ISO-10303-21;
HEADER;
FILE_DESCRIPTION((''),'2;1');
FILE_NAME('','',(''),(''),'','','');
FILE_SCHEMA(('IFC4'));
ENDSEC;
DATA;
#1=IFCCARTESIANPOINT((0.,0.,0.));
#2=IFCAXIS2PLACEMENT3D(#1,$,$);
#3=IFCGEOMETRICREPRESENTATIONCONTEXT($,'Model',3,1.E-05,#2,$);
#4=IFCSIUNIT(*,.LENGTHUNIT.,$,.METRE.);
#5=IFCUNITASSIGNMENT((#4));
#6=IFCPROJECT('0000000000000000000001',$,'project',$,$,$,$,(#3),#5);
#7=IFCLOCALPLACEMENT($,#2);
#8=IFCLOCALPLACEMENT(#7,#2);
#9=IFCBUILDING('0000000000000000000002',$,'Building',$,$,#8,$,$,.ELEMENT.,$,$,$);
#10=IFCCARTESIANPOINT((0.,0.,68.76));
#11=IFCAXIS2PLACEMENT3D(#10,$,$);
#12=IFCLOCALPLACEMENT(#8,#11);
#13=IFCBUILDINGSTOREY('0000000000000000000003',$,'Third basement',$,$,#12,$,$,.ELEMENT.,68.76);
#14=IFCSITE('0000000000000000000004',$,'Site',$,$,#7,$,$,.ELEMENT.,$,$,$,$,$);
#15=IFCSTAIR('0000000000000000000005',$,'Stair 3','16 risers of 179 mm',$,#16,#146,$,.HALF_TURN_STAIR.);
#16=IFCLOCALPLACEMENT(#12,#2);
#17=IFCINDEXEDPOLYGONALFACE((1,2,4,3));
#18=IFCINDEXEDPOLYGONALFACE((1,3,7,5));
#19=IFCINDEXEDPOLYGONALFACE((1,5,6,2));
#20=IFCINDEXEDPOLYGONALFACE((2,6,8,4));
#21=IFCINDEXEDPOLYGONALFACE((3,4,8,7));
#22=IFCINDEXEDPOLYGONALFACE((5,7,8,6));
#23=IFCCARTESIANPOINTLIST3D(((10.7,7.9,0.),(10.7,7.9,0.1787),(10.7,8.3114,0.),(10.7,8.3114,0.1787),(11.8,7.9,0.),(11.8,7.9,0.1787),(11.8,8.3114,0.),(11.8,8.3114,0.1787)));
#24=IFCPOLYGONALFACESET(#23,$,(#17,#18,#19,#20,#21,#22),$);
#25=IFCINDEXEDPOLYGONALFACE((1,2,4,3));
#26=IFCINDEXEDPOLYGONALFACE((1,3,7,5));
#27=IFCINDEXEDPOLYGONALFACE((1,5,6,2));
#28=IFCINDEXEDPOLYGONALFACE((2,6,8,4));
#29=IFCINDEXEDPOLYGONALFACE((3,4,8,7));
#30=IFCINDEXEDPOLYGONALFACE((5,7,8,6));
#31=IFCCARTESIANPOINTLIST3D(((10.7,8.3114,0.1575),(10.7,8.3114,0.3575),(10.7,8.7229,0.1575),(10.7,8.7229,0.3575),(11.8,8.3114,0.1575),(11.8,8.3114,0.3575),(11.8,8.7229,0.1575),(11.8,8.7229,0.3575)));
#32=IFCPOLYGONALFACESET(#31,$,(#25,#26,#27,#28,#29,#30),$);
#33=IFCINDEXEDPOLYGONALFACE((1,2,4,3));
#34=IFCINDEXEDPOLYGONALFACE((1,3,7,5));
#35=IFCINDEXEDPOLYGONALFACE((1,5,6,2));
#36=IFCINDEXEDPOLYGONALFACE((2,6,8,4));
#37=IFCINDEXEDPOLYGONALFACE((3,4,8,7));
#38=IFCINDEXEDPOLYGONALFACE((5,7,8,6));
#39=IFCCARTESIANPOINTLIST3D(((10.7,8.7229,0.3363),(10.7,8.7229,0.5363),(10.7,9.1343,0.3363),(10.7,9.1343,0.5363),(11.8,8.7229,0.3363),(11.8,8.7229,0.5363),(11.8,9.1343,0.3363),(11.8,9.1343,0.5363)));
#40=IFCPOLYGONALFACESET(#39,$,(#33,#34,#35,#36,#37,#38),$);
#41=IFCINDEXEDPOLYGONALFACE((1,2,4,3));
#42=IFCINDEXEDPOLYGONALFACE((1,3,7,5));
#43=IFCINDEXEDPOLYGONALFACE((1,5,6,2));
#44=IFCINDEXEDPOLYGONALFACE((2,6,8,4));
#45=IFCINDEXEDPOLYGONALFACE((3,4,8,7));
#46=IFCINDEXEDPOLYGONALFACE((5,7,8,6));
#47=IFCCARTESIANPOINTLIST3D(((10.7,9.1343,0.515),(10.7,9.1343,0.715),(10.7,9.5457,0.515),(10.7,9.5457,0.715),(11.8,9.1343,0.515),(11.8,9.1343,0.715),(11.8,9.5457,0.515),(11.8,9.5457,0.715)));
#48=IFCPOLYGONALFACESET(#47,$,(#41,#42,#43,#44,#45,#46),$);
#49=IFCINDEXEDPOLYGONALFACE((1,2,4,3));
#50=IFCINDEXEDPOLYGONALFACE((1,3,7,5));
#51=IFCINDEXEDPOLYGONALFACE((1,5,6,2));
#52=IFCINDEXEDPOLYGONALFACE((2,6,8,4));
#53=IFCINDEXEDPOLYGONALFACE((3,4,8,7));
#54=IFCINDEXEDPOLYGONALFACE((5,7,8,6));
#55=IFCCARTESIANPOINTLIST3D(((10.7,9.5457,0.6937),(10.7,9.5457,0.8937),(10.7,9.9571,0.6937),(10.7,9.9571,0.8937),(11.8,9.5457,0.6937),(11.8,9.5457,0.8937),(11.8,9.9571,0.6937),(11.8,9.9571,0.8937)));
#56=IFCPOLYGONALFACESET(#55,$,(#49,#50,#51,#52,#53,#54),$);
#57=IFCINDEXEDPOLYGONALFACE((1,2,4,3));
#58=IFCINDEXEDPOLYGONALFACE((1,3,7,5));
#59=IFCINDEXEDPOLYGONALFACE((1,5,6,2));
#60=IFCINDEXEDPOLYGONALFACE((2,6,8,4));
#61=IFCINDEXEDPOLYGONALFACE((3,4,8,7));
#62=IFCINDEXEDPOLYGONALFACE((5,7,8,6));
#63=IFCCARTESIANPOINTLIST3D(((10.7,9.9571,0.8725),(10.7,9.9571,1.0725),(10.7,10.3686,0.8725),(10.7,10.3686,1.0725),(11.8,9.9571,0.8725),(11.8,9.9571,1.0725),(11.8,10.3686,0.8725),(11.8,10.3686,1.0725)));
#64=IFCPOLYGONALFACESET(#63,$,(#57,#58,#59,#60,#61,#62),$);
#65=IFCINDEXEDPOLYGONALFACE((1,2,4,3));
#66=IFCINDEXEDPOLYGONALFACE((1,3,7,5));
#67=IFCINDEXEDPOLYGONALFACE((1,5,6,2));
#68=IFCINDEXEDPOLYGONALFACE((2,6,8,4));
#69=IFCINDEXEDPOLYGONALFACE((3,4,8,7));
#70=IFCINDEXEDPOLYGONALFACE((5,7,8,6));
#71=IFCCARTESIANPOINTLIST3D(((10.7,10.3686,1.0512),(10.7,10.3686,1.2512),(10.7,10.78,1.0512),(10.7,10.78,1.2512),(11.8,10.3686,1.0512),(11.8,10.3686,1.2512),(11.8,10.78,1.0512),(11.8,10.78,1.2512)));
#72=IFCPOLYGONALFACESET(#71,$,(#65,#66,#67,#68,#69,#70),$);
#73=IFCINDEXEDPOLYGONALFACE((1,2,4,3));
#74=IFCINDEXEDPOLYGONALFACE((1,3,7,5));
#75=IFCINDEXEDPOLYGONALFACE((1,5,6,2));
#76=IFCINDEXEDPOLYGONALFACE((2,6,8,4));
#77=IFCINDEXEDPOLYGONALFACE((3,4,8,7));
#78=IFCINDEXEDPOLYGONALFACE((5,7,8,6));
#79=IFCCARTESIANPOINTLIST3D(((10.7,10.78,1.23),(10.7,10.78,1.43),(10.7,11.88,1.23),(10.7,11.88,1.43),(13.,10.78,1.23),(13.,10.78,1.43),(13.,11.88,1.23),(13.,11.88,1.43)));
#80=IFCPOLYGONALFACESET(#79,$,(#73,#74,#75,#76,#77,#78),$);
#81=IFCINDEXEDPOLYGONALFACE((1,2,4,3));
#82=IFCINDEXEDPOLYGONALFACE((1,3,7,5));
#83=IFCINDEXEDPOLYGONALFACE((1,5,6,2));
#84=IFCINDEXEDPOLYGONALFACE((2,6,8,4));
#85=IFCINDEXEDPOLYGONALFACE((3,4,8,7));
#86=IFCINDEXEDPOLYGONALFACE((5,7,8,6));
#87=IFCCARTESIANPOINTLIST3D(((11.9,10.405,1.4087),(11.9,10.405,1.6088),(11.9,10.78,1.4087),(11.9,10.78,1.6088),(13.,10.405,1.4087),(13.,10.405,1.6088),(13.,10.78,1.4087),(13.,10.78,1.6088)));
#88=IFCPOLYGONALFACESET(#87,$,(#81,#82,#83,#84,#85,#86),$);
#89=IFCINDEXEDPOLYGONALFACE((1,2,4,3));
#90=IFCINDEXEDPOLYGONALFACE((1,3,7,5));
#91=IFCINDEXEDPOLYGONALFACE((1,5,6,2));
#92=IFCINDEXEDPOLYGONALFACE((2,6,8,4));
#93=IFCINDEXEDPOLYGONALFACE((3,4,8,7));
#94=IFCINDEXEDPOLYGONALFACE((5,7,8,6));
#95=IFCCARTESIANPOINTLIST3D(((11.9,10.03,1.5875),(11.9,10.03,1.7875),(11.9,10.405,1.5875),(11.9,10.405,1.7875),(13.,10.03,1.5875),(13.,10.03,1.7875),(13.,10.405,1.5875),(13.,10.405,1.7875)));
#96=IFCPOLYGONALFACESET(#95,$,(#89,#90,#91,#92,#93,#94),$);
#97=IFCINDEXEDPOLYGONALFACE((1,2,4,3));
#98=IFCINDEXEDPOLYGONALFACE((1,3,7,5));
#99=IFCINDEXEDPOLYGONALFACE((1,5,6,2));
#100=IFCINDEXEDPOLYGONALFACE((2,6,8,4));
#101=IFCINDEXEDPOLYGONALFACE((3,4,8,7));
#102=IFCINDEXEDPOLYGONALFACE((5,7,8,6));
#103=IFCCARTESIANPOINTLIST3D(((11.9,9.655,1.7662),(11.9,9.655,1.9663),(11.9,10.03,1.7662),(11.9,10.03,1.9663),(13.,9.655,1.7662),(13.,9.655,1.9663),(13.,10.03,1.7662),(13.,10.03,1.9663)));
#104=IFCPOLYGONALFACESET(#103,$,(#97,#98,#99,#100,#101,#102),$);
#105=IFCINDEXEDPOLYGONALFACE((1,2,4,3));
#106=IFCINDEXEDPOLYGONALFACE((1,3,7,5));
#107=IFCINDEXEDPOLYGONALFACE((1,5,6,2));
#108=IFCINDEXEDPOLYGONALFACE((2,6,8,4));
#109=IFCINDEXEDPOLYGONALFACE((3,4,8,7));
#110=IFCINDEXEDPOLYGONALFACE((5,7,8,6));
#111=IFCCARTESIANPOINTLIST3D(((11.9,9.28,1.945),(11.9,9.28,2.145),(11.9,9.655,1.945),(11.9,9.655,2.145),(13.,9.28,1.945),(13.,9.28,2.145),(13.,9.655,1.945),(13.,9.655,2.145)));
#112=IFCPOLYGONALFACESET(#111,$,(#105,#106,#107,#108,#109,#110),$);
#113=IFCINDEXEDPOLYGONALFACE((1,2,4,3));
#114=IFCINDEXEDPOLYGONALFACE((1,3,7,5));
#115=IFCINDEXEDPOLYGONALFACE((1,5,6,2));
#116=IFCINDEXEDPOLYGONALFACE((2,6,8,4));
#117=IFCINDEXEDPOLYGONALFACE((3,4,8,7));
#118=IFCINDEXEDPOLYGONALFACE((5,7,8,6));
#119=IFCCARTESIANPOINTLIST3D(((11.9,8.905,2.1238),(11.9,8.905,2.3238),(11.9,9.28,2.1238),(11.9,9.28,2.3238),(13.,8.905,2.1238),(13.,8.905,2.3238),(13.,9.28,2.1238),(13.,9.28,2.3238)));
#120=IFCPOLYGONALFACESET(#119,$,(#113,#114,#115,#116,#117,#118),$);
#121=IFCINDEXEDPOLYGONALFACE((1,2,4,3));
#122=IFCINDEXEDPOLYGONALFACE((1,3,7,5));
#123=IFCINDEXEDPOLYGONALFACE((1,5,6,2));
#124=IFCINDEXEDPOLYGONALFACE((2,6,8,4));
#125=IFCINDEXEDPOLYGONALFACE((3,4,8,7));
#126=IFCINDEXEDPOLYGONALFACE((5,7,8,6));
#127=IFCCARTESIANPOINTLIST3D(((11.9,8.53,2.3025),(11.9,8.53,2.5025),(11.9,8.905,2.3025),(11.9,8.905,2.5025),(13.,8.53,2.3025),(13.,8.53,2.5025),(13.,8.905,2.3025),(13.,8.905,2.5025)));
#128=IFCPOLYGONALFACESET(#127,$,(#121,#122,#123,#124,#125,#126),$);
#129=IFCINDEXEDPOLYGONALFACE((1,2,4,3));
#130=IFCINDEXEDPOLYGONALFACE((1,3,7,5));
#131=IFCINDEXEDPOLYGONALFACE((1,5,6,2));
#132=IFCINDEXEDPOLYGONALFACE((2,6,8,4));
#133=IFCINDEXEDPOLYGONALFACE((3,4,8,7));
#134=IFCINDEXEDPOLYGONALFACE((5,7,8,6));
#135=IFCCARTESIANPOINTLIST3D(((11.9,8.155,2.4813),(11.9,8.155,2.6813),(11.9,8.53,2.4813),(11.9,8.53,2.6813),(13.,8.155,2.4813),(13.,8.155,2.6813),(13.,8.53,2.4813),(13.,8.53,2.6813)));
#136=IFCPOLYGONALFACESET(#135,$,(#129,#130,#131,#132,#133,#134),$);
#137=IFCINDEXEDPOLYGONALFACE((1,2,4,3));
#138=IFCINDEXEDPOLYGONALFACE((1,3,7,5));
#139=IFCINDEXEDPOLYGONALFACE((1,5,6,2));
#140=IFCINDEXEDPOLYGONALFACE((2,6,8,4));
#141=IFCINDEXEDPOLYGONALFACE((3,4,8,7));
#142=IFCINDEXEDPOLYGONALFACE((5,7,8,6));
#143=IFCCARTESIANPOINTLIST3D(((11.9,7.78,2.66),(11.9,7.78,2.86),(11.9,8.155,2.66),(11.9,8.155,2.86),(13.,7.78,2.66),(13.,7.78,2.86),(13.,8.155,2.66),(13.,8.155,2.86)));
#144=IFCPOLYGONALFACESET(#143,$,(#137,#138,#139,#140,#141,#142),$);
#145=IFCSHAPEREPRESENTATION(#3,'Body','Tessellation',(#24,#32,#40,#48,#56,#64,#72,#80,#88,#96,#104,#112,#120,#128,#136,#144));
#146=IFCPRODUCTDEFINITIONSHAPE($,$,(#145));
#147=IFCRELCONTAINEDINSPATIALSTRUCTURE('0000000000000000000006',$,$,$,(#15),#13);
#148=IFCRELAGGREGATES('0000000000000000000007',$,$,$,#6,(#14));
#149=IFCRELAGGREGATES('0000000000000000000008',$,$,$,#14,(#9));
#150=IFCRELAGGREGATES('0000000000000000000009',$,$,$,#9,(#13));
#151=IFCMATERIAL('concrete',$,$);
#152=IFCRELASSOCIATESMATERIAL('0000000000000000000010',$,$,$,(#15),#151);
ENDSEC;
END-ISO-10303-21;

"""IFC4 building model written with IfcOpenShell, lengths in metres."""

from ifc_helpers import new_model, si_unit, frame, origin, place, context, project, spatial, polyline, outline, extrude, material, element, save


model = new_model("IFC4")

# Units and contexts
model_context = context("Model", 3, precision=1e-05, world=origin())
ifc_project = project(units=[si_unit("LENGTHUNIT", "METRE")], contexts=[model_context])

# Site, building, storey
site_placement = place(None, origin())
site = spatial("IfcSite", under=ifc_project, at=site_placement, Name="Site", CompositionType="ELEMENT")
building_placement = place(site_placement, origin())
building = spatial("IfcBuilding", under=site, at=building_placement, Name="Building", CompositionType="ELEMENT")
storey_placement = place(building_placement, frame((0.0, 0.0, 68.76)))
storey = spatial("IfcBuildingStorey", under=building, at=storey_placement, Name="Third basement", CompositionType="ELEMENT", Elevation=68.76)

# Shared definitions
ifc_material = material(Name="concrete")

# Stair
stair_1_placement = place(storey_placement, frame((11.25, 7.9, 0.0), z_axis=(0.0, 0.0, 1.0), x_axis=(0.0, 1.0, 0.0)))
element("IfcStair", 1, at=stair_1_placement, inside=storey, material=ifc_material, Name="Stair 3", Description="16 risers of 179 mm", PredefinedType="HALF_TURN_STAIR", context=model_context, shape_type="SweptSolid", body=[
    extrude(outline(polyline([(0.0, -0.55), (0.4114, -0.55), (0.4114, 0.55), (0.0, 0.55), (0.0, -0.55)])), origin(), (0.0, 0.0, 1.0), 0.1787),
    extrude(outline(polyline([(0.4114, -0.55), (0.8229, -0.55), (0.8229, 0.55), (0.4114, 0.55), (0.4114, -0.55)])), frame((0.0, 0.0, 0.1575)), (0.0, 0.0, 1.0), 0.2),
    extrude(outline(polyline([(0.8229, -0.55), (1.2343, -0.55), (1.2343, 0.55), (0.8229, 0.55), (0.8229, -0.55)])), frame((0.0, 0.0, 0.3362)), (0.0, 0.0, 1.0), 0.2),
    extrude(outline(polyline([(1.2343, -0.55), (1.6457, -0.55), (1.6457, 0.55), (1.2343, 0.55), (1.2343, -0.55)])), frame((0.0, 0.0, 0.515)), (0.0, 0.0, 1.0), 0.2),
    extrude(outline(polyline([(1.6457, -0.55), (2.0571, -0.55), (2.0571, 0.55), (1.6457, 0.55), (1.6457, -0.55)])), frame((0.0, 0.0, 0.6937)), (0.0, 0.0, 1.0), 0.2),
    extrude(outline(polyline([(2.0571, -0.55), (2.4686, -0.55), (2.4686, 0.55), (2.0571, 0.55), (2.0571, -0.55)])), frame((0.0, 0.0, 0.8725)), (0.0, 0.0, 1.0), 0.2),
    extrude(outline(polyline([(2.4686, -0.55), (2.88, -0.55), (2.88, 0.55), (2.4686, 0.55), (2.4686, -0.55)])), frame((0.0, 0.0, 1.0513)), (0.0, 0.0, 1.0), 0.2),
    extrude(outline(polyline([(2.88, -1.75), (3.98, -1.75), (3.98, 0.55), (2.88, 0.55), (2.88, -1.75)])), frame((0.0, 0.0, 1.23)), (0.0, 0.0, 1.0), 0.2),
    extrude(outline(polyline([(2.505, -1.75), (2.88, -1.75), (2.88, -0.65), (2.505, -0.65), (2.505, -1.75)])), frame((0.0, 0.0, 1.4087)), (0.0, 0.0, 1.0), 0.2),
    extrude(outline(polyline([(2.13, -1.75), (2.505, -1.75), (2.505, -0.65), (2.13, -0.65), (2.13, -1.75)])), frame((0.0, 0.0, 1.5875)), (0.0, 0.0, 1.0), 0.2),
    extrude(outline(polyline([(1.755, -1.75), (2.13, -1.75), (2.13, -0.65), (1.755, -0.65), (1.755, -1.75)])), frame((0.0, 0.0, 1.7663)), (0.0, 0.0, 1.0), 0.2),
    extrude(outline(polyline([(1.38, -1.75), (1.755, -1.75), (1.755, -0.65), (1.38, -0.65), (1.38, -1.75)])), frame((0.0, 0.0, 1.945)), (0.0, 0.0, 1.0), 0.2),
    extrude(outline(polyline([(1.005, -1.75), (1.38, -1.75), (1.38, -0.65), (1.005, -0.65), (1.005, -1.75)])), frame((0.0, 0.0, 2.1237)), (0.0, 0.0, 1.0), 0.2),
    extrude(outline(polyline([(0.63, -1.75), (1.005, -1.75), (1.005, -0.65), (0.63, -0.65), (0.63, -1.75)])), frame((0.0, 0.0, 2.3025)), (0.0, 0.0, 1.0), 0.2),
    extrude(outline(polyline([(0.255, -1.75), (0.63, -1.75), (0.63, -0.65), (0.255, -0.65), (0.255, -1.75)])), frame((0.0, 0.0, 2.4813)), (0.0, 0.0, 1.0), 0.2),
    extrude(outline(polyline([(-0.12, -1.75), (0.255, -1.75), (0.255, -0.65), (-0.12, -0.65), (-0.12, -1.75)])), frame((0.0, 0.0, 2.66)), (0.0, 0.0, 1.0), 0.2),
])

save(model, "model.ifc")
